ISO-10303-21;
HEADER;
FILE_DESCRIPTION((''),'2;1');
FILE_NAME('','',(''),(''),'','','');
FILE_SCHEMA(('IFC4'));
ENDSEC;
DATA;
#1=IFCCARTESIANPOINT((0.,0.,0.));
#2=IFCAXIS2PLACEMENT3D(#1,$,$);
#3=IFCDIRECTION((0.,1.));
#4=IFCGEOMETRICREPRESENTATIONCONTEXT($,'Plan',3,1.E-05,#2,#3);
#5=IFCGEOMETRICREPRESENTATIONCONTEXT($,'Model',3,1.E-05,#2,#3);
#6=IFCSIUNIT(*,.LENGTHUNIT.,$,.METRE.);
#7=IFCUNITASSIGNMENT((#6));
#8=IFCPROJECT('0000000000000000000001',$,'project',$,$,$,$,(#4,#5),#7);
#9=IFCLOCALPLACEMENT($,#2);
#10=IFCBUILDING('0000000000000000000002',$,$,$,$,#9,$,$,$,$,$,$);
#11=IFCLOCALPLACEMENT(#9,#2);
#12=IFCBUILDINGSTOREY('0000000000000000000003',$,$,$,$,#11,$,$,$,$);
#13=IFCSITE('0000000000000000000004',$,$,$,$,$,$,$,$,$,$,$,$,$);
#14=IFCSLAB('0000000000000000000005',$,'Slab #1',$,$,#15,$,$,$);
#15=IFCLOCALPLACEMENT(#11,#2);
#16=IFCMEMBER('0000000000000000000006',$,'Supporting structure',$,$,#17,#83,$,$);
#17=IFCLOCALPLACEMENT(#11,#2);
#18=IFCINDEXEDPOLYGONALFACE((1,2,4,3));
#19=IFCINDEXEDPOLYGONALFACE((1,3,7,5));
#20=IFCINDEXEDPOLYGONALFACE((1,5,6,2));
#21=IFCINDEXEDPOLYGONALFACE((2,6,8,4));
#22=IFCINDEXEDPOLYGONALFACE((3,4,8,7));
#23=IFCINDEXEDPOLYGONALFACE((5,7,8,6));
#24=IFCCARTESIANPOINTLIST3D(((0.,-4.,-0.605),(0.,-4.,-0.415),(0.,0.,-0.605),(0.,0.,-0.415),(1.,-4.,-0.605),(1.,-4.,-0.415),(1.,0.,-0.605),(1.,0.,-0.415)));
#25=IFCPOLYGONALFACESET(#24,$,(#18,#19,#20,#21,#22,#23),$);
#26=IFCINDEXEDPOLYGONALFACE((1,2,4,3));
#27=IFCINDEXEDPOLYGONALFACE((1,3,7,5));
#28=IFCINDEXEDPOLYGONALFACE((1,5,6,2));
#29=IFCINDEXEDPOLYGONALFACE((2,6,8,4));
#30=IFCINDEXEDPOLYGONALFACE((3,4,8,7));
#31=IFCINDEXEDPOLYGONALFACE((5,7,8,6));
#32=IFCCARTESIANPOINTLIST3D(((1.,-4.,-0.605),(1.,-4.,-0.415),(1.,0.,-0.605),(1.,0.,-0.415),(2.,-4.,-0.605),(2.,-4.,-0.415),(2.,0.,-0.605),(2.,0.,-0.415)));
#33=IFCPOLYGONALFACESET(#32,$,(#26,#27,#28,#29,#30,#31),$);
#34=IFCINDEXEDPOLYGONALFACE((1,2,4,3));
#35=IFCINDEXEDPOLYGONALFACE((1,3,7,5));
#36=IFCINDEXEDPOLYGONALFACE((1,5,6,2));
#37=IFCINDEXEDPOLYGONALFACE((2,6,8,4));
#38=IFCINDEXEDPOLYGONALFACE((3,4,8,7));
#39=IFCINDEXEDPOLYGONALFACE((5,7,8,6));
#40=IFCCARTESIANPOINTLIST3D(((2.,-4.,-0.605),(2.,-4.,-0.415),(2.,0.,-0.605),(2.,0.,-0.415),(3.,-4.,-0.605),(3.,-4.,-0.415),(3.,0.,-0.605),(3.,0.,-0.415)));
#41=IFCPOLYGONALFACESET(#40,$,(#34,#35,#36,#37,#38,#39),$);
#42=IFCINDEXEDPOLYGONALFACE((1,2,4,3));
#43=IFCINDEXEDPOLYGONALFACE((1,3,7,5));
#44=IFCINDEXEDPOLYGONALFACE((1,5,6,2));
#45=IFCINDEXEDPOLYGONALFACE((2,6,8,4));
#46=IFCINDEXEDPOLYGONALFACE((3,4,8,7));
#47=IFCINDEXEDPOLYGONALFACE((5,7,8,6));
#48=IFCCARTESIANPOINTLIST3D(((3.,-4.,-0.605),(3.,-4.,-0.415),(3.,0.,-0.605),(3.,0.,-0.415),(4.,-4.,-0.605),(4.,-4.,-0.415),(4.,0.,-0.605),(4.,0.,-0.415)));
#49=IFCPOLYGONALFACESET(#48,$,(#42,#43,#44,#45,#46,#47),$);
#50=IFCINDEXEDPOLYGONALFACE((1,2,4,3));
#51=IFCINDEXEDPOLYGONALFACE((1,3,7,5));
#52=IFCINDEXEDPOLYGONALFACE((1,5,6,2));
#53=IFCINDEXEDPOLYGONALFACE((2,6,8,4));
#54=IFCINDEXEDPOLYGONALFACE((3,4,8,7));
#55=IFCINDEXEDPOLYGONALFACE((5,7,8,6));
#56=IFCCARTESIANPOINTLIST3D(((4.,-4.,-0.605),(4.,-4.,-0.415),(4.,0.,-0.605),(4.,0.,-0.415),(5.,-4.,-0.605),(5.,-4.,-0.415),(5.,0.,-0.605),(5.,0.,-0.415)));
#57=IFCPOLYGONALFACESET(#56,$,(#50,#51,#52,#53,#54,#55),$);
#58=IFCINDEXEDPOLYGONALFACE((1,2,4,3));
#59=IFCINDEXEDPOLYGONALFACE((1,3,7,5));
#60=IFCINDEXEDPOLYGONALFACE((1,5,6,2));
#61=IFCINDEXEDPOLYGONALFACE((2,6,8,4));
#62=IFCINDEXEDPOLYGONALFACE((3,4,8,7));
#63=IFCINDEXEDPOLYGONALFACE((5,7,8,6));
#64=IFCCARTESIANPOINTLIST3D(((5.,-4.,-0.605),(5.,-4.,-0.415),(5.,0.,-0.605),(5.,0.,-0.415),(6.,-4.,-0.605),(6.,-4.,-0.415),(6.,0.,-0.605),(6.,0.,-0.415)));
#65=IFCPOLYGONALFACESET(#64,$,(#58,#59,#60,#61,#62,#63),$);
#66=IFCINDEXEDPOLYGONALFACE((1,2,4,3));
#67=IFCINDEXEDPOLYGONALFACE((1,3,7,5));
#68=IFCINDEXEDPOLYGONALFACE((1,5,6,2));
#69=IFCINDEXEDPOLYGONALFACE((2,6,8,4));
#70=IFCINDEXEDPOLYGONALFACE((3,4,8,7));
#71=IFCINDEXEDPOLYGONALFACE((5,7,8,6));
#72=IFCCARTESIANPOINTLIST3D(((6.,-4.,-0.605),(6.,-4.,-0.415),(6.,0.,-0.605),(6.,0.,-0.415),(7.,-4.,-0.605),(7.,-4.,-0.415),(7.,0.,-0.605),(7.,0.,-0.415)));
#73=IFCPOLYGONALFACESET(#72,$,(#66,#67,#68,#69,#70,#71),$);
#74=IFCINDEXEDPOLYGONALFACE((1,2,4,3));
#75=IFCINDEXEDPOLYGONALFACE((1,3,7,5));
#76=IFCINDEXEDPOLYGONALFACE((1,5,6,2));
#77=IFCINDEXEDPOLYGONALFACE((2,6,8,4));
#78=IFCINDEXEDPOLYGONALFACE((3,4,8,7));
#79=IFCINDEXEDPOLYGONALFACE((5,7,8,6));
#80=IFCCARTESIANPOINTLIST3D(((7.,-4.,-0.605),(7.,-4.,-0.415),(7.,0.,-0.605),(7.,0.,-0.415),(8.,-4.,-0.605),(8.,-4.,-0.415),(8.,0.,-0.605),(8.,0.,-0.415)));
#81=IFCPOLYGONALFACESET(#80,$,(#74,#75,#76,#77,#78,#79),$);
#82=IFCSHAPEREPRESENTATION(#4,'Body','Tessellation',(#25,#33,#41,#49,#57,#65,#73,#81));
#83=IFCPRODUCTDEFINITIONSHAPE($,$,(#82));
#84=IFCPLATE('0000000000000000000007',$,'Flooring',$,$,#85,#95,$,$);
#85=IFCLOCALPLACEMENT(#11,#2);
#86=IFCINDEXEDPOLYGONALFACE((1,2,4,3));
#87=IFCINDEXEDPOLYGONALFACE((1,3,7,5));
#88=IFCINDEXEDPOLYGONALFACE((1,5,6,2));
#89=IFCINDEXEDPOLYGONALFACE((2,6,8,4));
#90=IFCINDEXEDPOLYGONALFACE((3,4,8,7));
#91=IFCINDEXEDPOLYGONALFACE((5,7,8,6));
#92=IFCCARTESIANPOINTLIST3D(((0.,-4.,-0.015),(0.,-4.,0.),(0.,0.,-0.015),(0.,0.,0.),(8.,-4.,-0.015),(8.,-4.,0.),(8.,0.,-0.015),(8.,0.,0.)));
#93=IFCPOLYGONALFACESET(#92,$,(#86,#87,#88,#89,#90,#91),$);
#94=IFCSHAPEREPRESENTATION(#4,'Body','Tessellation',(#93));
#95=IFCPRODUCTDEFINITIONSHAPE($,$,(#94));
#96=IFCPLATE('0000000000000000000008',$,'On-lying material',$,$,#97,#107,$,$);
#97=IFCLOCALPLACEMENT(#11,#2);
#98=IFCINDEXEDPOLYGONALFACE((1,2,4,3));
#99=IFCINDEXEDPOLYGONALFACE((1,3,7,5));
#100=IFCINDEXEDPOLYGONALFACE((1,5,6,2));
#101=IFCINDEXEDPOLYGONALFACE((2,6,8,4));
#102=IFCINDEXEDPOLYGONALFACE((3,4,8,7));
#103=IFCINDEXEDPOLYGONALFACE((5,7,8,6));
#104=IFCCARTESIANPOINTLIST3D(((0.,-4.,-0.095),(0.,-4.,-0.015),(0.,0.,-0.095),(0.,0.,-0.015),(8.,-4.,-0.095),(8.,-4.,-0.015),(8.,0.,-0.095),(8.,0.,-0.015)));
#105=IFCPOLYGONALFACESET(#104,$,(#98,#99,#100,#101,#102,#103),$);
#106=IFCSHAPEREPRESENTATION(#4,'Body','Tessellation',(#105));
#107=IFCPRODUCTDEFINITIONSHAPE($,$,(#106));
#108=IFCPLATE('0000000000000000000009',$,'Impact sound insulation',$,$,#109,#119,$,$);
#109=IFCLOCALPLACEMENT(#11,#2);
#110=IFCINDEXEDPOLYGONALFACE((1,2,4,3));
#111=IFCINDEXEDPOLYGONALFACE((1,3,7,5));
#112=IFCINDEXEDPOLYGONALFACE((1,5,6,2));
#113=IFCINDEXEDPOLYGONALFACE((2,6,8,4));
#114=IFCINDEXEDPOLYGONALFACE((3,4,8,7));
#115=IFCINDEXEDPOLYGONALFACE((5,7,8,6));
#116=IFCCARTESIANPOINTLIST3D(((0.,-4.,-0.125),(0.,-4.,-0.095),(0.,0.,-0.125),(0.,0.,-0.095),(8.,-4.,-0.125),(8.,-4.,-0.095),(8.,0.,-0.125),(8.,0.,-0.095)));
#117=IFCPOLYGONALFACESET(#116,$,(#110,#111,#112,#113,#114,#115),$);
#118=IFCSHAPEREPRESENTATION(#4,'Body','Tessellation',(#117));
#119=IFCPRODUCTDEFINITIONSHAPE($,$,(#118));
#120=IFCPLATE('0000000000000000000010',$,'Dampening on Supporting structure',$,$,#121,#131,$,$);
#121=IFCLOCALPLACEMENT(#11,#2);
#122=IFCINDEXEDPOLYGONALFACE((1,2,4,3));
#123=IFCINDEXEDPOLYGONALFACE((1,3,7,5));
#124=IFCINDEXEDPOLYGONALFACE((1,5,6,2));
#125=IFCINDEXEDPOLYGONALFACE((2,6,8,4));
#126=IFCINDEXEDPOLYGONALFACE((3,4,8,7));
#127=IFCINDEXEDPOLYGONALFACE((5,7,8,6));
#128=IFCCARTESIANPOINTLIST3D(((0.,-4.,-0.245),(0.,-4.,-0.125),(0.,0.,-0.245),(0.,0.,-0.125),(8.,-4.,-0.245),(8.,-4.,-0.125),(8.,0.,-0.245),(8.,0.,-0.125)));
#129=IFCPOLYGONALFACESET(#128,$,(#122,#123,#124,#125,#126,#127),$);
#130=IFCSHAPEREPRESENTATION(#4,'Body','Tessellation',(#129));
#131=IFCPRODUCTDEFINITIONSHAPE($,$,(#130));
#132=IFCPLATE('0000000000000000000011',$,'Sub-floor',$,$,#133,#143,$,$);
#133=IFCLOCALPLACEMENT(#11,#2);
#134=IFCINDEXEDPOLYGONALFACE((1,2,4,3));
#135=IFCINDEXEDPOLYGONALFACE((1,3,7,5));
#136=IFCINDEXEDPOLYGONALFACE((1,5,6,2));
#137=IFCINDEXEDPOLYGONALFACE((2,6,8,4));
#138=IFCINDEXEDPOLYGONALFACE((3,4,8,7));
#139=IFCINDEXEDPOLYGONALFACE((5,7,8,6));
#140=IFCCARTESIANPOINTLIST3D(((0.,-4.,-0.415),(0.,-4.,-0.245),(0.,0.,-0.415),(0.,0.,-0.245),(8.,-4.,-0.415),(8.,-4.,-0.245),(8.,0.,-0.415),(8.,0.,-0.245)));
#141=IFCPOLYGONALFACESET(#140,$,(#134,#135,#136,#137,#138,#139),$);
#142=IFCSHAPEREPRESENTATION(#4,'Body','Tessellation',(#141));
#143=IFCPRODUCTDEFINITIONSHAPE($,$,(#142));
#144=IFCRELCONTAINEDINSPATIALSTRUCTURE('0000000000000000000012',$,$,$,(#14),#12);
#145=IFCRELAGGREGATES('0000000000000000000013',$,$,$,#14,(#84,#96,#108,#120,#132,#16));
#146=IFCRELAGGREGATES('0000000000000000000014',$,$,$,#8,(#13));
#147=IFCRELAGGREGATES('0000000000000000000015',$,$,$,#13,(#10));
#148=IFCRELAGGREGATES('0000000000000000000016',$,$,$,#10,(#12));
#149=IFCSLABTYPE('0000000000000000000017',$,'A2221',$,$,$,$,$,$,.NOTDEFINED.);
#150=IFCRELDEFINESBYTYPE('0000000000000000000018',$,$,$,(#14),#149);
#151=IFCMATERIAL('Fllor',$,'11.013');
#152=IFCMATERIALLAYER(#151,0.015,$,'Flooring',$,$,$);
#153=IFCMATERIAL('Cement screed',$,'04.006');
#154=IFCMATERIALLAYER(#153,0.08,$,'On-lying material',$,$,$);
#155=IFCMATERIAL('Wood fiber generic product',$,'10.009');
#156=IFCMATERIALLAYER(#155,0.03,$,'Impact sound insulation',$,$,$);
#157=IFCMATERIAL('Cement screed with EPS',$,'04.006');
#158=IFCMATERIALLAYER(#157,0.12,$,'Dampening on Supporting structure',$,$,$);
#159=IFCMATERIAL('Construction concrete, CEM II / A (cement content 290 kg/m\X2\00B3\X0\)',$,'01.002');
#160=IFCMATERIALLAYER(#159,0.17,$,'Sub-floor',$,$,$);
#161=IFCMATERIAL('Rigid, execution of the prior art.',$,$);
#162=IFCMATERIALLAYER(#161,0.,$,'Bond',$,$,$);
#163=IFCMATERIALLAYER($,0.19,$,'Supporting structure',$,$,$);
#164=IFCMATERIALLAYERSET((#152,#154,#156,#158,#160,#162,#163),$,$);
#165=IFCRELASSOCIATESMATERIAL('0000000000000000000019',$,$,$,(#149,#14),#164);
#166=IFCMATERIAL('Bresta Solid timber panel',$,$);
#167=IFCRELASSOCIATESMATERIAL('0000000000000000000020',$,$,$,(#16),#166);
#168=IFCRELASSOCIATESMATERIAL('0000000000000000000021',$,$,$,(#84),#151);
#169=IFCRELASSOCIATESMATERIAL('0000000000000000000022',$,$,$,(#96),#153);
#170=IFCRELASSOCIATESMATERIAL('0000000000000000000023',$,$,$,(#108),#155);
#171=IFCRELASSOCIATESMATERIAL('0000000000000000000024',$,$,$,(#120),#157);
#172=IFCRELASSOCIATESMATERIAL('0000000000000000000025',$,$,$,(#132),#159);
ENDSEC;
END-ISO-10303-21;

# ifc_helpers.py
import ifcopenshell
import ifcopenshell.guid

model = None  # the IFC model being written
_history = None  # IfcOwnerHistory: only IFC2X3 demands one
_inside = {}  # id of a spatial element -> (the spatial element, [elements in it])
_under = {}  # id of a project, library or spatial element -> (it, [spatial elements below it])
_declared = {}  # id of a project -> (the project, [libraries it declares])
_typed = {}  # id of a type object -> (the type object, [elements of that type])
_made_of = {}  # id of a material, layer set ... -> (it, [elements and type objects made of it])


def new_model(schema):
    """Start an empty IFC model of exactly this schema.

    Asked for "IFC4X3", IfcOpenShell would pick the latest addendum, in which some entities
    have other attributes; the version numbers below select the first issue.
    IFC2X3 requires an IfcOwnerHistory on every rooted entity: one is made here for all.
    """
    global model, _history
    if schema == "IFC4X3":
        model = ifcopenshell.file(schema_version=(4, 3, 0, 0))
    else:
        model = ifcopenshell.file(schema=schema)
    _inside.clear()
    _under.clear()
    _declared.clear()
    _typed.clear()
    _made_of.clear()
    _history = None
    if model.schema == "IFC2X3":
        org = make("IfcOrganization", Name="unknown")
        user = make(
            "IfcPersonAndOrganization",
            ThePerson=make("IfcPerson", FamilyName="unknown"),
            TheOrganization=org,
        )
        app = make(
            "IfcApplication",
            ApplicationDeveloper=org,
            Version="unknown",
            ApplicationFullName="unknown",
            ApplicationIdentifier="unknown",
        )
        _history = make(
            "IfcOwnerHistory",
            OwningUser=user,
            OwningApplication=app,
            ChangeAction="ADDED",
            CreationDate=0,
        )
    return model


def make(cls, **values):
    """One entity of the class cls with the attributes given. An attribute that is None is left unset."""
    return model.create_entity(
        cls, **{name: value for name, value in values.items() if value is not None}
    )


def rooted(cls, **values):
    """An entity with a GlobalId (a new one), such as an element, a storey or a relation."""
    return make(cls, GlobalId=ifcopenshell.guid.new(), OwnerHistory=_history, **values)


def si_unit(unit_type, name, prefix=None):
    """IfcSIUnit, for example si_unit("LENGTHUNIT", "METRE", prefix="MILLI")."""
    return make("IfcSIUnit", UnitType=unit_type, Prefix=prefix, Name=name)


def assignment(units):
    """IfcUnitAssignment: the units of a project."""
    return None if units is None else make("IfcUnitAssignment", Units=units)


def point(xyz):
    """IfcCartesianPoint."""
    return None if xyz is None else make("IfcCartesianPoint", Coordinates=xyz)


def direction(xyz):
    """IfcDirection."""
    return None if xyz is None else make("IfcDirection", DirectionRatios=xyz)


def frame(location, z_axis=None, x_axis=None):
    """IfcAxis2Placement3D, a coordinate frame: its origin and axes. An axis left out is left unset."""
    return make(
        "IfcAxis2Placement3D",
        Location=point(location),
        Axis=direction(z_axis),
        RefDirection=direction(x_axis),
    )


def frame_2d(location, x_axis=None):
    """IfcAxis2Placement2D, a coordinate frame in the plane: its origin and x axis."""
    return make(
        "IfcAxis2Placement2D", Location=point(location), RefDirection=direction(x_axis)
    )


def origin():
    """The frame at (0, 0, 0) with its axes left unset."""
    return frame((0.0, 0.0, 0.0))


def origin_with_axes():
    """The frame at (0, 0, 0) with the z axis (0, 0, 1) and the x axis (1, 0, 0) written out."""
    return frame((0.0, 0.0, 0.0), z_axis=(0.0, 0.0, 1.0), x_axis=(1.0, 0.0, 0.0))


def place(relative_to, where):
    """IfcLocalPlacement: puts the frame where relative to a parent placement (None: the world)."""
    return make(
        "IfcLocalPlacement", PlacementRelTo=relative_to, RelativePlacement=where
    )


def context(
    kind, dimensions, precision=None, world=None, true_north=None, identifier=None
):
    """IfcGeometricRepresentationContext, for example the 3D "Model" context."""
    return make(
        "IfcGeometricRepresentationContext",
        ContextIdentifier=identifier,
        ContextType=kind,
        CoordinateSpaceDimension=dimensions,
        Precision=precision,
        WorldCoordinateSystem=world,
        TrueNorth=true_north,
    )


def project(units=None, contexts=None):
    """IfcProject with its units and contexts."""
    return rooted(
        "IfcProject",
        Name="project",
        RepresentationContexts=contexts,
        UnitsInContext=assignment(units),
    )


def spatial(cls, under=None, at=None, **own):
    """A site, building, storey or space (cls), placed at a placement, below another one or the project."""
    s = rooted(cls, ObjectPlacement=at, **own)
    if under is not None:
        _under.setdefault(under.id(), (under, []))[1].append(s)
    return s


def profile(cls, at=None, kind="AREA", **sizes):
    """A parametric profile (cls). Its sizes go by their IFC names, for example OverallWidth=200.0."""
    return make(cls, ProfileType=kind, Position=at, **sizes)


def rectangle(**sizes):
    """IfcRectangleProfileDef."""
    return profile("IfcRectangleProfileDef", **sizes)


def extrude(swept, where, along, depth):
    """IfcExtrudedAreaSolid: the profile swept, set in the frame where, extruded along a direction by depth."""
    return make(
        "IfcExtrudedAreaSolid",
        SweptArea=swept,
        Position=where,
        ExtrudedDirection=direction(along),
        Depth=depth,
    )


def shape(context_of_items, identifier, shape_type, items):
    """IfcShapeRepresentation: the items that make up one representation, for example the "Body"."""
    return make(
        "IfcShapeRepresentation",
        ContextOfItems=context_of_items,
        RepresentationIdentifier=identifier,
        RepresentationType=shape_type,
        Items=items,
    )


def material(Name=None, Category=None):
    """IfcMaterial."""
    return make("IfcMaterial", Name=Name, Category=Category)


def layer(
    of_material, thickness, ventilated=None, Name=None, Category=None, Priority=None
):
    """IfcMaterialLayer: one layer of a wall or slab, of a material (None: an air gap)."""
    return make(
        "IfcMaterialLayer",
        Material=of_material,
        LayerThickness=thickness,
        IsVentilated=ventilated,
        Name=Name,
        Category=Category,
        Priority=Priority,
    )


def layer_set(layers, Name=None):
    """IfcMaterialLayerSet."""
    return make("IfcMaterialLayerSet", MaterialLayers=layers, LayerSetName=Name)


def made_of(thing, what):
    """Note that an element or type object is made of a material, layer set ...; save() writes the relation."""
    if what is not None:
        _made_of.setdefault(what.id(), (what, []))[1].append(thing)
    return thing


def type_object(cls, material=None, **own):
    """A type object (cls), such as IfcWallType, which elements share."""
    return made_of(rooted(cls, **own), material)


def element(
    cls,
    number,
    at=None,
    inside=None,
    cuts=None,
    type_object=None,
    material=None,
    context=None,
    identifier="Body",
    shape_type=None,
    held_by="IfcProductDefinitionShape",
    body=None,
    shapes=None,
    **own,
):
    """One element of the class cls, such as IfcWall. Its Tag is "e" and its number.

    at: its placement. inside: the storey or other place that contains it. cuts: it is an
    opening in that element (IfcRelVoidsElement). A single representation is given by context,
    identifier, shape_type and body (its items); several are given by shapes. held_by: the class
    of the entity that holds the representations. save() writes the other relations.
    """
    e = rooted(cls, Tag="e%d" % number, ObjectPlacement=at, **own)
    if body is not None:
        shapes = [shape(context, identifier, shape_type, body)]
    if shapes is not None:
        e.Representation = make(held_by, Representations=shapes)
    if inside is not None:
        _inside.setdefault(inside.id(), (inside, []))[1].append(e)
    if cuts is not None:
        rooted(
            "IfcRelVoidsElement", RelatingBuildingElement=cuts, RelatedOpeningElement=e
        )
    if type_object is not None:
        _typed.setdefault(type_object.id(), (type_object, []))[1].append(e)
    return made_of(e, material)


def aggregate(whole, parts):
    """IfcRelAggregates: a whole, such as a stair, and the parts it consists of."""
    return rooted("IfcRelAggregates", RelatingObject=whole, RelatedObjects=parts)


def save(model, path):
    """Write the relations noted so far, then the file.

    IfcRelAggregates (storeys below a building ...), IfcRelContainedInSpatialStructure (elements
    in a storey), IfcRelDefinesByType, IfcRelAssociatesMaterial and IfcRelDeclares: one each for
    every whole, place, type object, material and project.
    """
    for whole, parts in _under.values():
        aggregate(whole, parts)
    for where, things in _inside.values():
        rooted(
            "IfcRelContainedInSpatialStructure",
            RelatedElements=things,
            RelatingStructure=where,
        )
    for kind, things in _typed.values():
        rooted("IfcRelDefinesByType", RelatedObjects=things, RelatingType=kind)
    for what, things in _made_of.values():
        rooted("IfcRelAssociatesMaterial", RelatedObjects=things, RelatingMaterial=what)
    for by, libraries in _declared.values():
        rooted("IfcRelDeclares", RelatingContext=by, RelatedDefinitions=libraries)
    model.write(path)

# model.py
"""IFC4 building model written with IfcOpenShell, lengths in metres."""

from ifc_helpers import new_model, si_unit, direction, frame, frame_2d, origin, origin_with_axes, place, context, project, spatial, rectangle, extrude, material, layer, layer_set, type_object, element, aggregate, save


model = new_model("IFC4")

# Units and contexts
plan_context = context("Plan", 3, precision=1e-05, world=origin(), true_north=direction((0.0, 1.0)))
model_context = context("Model", 3, precision=1e-05, world=origin(), true_north=direction((0.0, 1.0)))
ifc_project = project(units=[si_unit("LENGTHUNIT", "METRE")], contexts=[plan_context, model_context])

# Site, building, storey
site = spatial("IfcSite", under=ifc_project)
building_placement = place(None, origin())
building = spatial("IfcBuilding", under=site, at=building_placement)
storey_placement = place(building_placement, origin())
storey = spatial("IfcBuildingStorey", under=building, at=storey_placement)

# Slab, member, plates
ifc_material_1 = material(Name="Fllor", Category="11.013")
ifc_layer_1 = layer(ifc_material_1, 0.015, Name="Flooring")
ifc_material_2 = material(Name="Cement screed", Category="04.006")
ifc_layer_2 = layer(ifc_material_2, 0.08, Name="On-lying material")
ifc_material_3 = material(Name="Wood fiber generic product", Category="10.009")
ifc_layer_3 = layer(ifc_material_3, 0.03, Name="Impact sound insulation")
ifc_material_4 = material(Name="Cement screed with EPS", Category="04.006")
ifc_layer_4 = layer(ifc_material_4, 0.12, Name="Dampening on Supporting structure")
ifc_material_5 = material(Name="Construction concrete, CEM II / A (cement content 290 kg/m³)", Category="01.002")
ifc_layer_5 = layer(ifc_material_5, 0.17, Name="Sub-floor")
ifc_material_6 = material(Name="Rigid, execution of the prior art.")
ifc_layer_6 = layer(ifc_material_6, 0.0, Name="Bond")
ifc_layer_7 = layer(None, 0.19, Name="Supporting structure")
ifc_layer_set = layer_set([ifc_layer_1, ifc_layer_2, ifc_layer_3, ifc_layer_4, ifc_layer_5, ifc_layer_6, ifc_layer_7])
slab_type = type_object("IfcSlabType", Name="A2221", PredefinedType="NOTDEFINED", material=ifc_layer_set)
slab_placement = place(None, frame((0.0, 0.0, 0.0), z_axis=(0.0, 0.0, -1.0), x_axis=(1.0, 0.0, 0.0)))
slab = element("IfcSlab", 1, at=slab_placement, inside=storey, type_object=slab_type, material=ifc_layer_set, Name="Slab #1")
ifc_material_7 = material(Name="Bresta Solid timber panel")
member_placement = place(slab_placement, origin())
member = element("IfcMember", 2, at=member_placement, material=ifc_material_7, Name="Supporting structure", context=plan_context, shape_type="SweptSolid", body=[
    extrude(rectangle(XDim=1.0, YDim=0.19, at=frame_2d((0.5, 0.095), x_axis=(1.0, 0.0))), frame((0.0, 4.0, 0.415), z_axis=(0.0, -1.0, 0.0), x_axis=(1.0, 0.0, 0.0)), (0.0, 0.0, 1.0), 4.0),
    extrude(rectangle(XDim=1.0, YDim=0.19, at=frame_2d((0.5, 0.095), x_axis=(1.0, 0.0))), frame((1.0, 4.0, 0.415), z_axis=(0.0, -1.0, 0.0), x_axis=(1.0, 0.0, 0.0)), (0.0, 0.0, 1.0), 4.0),
    extrude(rectangle(XDim=1.0, YDim=0.19, at=frame_2d((0.5, 0.095), x_axis=(1.0, 0.0))), frame((2.0, 4.0, 0.415), z_axis=(0.0, -1.0, 0.0), x_axis=(1.0, 0.0, 0.0)), (0.0, 0.0, 1.0), 4.0),
    extrude(rectangle(XDim=1.0, YDim=0.19, at=frame_2d((0.5, 0.095), x_axis=(1.0, 0.0))), frame((3.0, 4.0, 0.415), z_axis=(0.0, -1.0, 0.0), x_axis=(1.0, 0.0, 0.0)), (0.0, 0.0, 1.0), 4.0),
    extrude(rectangle(XDim=1.0, YDim=0.19, at=frame_2d((0.5, 0.095), x_axis=(1.0, 0.0))), frame((4.0, 4.0, 0.415), z_axis=(0.0, -1.0, 0.0), x_axis=(1.0, 0.0, 0.0)), (0.0, 0.0, 1.0), 4.0),
    extrude(rectangle(XDim=1.0, YDim=0.19, at=frame_2d((0.5, 0.095), x_axis=(1.0, 0.0))), frame((5.0, 4.0, 0.415), z_axis=(0.0, -1.0, 0.0), x_axis=(1.0, 0.0, 0.0)), (0.0, 0.0, 1.0), 4.0),
    extrude(rectangle(XDim=1.0, YDim=0.19, at=frame_2d((0.5, 0.095), x_axis=(1.0, 0.0))), frame((6.0, 4.0, 0.415), z_axis=(0.0, -1.0, 0.0), x_axis=(1.0, 0.0, 0.0)), (0.0, 0.0, 1.0), 4.0),
    extrude(rectangle(XDim=1.0, YDim=0.19, at=frame_2d((0.5, 0.095), x_axis=(1.0, 0.0))), frame((7.0, 4.0, 0.415), z_axis=(0.0, -1.0, 0.0), x_axis=(1.0, 0.0, 0.0)), (0.0, 0.0, 1.0), 4.0),
])
plate_1_placement = place(slab_placement, origin())
plate_1 = element("IfcPlate", 3, at=plate_1_placement, material=ifc_material_1, Name="Flooring", context=plan_context, shape_type="SweptSolid", body=[
    extrude(rectangle(XDim=8.0, YDim=4.0, at=frame_2d((4.0, 2.0), x_axis=(1.0, 0.0))), origin_with_axes(), (0.0, 0.0, 1.0), 0.015),
])
plate_2_placement = place(slab_placement, origin())
plate_2 = element("IfcPlate", 4, at=plate_2_placement, material=ifc_material_2, Name="On-lying material", context=plan_context, shape_type="SweptSolid", body=[
    extrude(rectangle(XDim=8.0, YDim=4.0, at=frame_2d((4.0, 2.0), x_axis=(1.0, 0.0))), frame((0.0, 0.0, 0.015), z_axis=(0.0, 0.0, 1.0), x_axis=(1.0, 0.0, 0.0)), (0.0, 0.0, 1.0), 0.08),
])
plate_3_placement = place(slab_placement, origin())
plate_3 = element("IfcPlate", 5, at=plate_3_placement, material=ifc_material_3, Name="Impact sound insulation", context=plan_context, shape_type="SweptSolid", body=[
    extrude(rectangle(XDim=8.0, YDim=4.0, at=frame_2d((4.0, 2.0), x_axis=(1.0, 0.0))), frame((0.0, 0.0, 0.095), z_axis=(0.0, 0.0, 1.0), x_axis=(1.0, 0.0, 0.0)), (0.0, 0.0, 1.0), 0.03),
])
plate_4_placement = place(slab_placement, origin())
plate_4 = element("IfcPlate", 6, at=plate_4_placement, material=ifc_material_4, Name="Dampening on Supporting structure", context=plan_context, shape_type="SweptSolid", body=[
    extrude(rectangle(XDim=8.0, YDim=4.0, at=frame_2d((4.0, 2.0), x_axis=(1.0, 0.0))), frame((0.0, 0.0, 0.125), z_axis=(0.0, 0.0, 1.0), x_axis=(1.0, 0.0, 0.0)), (0.0, 0.0, 1.0), 0.12),
])
plate_5_placement = place(slab_placement, origin())
plate_5 = element("IfcPlate", 7, at=plate_5_placement, material=ifc_material_5, Name="Sub-floor", context=plan_context, shape_type="SweptSolid", body=[
    extrude(rectangle(XDim=8.0, YDim=4.0, at=frame_2d((4.0, 2.0), x_axis=(1.0, 0.0))), frame((0.0, 0.0, 0.245), z_axis=(0.0, 0.0, 1.0), x_axis=(1.0, 0.0, 0.0)), (0.0, 0.0, 1.0), 0.17),
])
aggregate(slab, [plate_1, plate_2, plate_3, plate_4, plate_5, member])

save(model, "model.ifc")
